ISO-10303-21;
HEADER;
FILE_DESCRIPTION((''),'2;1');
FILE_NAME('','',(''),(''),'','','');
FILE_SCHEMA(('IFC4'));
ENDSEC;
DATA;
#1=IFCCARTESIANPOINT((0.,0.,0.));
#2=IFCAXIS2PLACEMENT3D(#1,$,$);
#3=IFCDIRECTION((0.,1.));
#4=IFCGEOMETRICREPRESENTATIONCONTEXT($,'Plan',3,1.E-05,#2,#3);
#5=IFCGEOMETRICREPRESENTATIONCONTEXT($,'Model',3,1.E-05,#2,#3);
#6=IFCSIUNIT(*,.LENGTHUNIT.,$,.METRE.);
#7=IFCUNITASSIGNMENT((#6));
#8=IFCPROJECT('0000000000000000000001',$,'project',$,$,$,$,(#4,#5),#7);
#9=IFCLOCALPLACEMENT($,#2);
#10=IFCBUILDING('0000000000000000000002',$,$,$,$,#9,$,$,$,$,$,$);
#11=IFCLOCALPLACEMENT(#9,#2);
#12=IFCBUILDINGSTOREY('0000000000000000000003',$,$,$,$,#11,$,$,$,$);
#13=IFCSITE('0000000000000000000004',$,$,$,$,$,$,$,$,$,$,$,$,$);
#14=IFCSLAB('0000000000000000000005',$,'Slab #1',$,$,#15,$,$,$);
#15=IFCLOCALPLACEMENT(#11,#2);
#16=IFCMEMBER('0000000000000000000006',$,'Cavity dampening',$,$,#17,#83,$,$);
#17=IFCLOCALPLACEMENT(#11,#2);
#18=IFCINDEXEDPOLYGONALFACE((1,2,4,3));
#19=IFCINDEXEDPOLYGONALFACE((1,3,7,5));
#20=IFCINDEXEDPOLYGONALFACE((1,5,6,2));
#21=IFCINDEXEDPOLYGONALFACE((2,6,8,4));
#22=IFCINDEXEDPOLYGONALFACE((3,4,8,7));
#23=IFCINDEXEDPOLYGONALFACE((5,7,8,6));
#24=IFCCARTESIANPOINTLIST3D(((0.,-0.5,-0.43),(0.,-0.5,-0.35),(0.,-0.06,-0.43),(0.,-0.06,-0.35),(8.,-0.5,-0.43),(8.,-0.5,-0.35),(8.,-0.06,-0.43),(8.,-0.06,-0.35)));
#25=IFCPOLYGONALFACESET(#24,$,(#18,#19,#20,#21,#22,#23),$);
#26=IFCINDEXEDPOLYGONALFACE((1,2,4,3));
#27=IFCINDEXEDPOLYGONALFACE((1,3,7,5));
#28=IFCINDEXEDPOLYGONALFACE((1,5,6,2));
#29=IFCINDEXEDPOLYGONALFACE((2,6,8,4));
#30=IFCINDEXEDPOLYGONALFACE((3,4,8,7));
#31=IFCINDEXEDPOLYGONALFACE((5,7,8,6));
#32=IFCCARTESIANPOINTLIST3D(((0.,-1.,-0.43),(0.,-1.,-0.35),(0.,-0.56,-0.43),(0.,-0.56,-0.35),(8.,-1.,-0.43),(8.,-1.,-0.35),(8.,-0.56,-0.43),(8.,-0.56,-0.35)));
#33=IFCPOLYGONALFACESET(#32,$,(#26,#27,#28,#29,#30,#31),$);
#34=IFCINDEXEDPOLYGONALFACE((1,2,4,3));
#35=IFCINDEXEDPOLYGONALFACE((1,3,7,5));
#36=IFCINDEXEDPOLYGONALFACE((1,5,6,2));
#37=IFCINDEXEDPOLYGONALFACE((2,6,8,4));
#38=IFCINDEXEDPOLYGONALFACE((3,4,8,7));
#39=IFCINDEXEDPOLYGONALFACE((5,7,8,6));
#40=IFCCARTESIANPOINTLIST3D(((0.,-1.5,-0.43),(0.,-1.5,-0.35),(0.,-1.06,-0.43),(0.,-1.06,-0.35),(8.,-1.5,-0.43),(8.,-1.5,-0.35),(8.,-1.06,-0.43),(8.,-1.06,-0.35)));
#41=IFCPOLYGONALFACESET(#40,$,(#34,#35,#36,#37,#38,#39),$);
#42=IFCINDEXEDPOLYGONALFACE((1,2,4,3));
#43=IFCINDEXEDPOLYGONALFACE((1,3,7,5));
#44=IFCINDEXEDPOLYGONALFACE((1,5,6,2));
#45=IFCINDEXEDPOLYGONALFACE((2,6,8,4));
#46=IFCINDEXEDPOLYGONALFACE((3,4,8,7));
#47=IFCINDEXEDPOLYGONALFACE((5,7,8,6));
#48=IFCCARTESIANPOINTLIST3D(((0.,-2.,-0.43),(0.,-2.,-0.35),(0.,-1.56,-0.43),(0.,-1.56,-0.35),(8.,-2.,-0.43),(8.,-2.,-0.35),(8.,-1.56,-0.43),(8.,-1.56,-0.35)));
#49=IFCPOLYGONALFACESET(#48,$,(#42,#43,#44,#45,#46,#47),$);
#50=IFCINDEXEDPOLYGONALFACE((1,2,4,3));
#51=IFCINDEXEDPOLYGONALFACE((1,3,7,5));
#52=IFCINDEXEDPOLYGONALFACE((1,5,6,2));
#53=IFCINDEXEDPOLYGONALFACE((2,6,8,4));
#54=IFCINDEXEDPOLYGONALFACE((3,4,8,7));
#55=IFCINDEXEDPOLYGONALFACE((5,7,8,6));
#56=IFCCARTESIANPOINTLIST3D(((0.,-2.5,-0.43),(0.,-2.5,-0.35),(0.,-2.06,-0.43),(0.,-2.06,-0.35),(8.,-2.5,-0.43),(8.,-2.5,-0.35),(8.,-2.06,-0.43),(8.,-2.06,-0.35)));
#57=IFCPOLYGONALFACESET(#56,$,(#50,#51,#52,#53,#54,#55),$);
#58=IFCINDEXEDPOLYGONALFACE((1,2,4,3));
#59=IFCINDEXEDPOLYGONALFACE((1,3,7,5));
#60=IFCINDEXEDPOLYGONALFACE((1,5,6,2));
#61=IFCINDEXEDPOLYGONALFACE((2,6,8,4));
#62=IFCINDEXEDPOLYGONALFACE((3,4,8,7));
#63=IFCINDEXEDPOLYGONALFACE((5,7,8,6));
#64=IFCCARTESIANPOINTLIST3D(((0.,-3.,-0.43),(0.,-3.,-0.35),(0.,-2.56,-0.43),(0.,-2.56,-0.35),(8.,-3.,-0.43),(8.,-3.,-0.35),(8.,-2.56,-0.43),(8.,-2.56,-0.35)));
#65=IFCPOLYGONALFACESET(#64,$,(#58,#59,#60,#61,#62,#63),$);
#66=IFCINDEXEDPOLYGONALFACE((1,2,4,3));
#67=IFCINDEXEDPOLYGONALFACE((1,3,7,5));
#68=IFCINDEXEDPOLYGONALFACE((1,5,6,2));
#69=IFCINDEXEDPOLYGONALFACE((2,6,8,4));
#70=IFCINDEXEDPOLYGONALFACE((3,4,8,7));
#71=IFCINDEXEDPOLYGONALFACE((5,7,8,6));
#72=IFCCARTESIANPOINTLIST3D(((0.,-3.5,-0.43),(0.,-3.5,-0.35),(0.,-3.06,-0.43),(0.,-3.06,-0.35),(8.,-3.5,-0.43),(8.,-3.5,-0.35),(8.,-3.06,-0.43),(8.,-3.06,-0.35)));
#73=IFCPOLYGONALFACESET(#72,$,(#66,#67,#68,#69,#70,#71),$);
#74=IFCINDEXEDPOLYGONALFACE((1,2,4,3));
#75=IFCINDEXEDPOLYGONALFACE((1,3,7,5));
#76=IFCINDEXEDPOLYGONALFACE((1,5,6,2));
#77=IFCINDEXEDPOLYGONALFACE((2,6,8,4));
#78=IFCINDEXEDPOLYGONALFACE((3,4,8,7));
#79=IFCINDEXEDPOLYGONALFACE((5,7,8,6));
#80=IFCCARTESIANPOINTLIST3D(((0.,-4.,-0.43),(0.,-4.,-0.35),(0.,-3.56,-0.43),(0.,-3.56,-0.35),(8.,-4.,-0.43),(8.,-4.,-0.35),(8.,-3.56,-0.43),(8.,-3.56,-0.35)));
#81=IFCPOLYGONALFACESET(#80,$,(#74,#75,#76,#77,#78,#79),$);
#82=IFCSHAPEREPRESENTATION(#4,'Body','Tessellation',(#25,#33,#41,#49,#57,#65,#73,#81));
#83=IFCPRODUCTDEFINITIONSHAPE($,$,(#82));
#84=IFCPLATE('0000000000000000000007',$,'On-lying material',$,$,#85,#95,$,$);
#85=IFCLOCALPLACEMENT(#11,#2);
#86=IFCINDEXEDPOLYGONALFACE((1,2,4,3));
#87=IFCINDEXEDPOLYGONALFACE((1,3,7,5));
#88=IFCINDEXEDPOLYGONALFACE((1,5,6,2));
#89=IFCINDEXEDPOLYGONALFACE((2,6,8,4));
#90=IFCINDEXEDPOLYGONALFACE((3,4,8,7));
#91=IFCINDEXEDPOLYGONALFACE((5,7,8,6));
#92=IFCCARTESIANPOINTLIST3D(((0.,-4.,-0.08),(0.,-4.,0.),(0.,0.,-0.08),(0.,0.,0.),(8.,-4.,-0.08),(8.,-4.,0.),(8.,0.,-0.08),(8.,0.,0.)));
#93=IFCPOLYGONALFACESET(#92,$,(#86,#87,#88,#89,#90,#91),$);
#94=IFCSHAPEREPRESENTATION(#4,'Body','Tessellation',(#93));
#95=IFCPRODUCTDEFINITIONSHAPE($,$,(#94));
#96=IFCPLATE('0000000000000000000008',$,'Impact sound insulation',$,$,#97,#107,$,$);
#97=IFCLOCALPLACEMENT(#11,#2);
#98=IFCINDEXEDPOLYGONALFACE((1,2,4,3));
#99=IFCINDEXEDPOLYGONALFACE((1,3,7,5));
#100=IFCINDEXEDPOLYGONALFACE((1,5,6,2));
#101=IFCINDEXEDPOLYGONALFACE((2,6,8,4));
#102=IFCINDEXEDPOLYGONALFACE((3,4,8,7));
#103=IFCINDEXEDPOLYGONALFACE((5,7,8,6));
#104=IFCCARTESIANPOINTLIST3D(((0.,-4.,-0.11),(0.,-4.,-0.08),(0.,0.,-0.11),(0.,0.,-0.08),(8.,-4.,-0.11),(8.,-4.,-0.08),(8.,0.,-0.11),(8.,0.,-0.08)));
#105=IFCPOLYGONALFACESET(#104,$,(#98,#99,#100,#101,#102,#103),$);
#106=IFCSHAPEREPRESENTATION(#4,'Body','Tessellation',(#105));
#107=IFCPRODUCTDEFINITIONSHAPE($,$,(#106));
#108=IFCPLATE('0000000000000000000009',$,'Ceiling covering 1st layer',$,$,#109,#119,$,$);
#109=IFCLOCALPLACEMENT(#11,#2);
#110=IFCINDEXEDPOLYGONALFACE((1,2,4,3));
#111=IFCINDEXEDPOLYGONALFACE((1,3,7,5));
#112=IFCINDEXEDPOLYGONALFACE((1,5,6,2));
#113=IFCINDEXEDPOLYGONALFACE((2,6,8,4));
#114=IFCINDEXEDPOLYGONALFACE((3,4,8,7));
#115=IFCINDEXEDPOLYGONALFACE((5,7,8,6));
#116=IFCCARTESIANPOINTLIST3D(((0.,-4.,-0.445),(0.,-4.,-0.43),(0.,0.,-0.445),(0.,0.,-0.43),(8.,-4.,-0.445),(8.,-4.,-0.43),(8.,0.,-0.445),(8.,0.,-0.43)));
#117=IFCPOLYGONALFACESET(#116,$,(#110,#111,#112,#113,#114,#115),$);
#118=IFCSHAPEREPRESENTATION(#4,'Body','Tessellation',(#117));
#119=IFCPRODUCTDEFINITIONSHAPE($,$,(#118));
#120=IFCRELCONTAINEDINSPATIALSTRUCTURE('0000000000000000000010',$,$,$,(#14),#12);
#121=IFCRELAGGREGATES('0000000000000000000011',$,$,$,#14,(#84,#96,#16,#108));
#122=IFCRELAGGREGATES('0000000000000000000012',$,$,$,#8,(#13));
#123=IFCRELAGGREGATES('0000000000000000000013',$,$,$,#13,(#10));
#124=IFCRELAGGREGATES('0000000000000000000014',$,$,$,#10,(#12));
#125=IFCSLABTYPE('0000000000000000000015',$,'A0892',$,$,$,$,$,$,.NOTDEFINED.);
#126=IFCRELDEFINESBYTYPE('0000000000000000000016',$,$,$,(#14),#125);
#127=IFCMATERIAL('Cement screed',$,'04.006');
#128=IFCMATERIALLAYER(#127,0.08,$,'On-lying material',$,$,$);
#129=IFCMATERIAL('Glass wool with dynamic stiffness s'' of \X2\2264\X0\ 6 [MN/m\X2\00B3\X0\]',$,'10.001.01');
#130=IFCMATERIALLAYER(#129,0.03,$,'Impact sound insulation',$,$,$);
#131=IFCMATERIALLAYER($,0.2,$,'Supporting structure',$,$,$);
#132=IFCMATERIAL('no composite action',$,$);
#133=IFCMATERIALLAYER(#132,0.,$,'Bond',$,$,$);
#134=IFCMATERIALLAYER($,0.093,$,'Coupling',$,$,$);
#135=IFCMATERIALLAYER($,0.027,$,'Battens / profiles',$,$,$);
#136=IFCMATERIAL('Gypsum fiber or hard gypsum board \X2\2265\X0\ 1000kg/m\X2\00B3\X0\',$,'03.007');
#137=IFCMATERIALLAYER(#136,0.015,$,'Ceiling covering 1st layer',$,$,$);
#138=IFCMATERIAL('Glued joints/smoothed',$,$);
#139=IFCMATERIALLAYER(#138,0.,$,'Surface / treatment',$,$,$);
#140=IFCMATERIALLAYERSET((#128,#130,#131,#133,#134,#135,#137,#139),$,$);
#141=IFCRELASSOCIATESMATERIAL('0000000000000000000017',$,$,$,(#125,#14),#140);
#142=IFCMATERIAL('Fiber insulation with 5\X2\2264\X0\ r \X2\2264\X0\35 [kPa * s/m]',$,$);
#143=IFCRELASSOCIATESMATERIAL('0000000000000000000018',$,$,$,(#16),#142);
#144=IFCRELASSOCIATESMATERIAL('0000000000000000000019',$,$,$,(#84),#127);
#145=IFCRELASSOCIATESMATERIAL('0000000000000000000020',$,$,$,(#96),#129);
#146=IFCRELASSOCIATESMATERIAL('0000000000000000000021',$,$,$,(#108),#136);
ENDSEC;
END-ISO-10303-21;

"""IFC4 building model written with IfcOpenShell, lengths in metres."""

from ifc_helpers import new_model, si_unit, direction, frame, frame_2d, origin, origin_with_axes, place, context, project, spatial, rectangle, extrude, material, layer, layer_set, type_object, element, aggregate, save


model = new_model("IFC4")

# Units and contexts
plan_context = context("Plan", 3, precision=1e-05, world=origin(), true_north=direction((0.0, 1.0)))
model_context = context("Model", 3, precision=1e-05, world=origin(), true_north=direction((0.0, 1.0)))
ifc_project = project(units=[si_unit("LENGTHUNIT", "METRE")], contexts=[plan_context, model_context])

# Site, building, storey
site = spatial("IfcSite", under=ifc_project)
building_placement = place(None, origin())
building = spatial("IfcBuilding", under=site, at=building_placement)
storey_placement = place(building_placement, origin())
storey = spatial("IfcBuildingStorey", under=building, at=storey_placement)

# Slab, member, plates
ifc_material_1 = material(Name="Cement screed", Category="04.006")
ifc_layer_1 = layer(ifc_material_1, 0.08, Name="On-lying material")
ifc_material_2 = material(Name="Glass wool with dynamic stiffness s' of ≤ 6 [MN/m³]", Category="10.001.01")
ifc_layer_2 = layer(ifc_material_2, 0.03, Name="Impact sound insulation")
ifc_layer_3 = layer(None, 0.2, Name="Supporting structure")
ifc_material_3 = material(Name="no composite action")
ifc_layer_4 = layer(ifc_material_3, 0.0, Name="Bond")
ifc_layer_5 = layer(None, 0.093, Name="Coupling")
ifc_layer_6 = layer(None, 0.027, Name="Battens / profiles")
ifc_material_4 = material(Name="Gypsum fiber or hard gypsum board ≥ 1000kg/m³", Category="03.007")
ifc_layer_7 = layer(ifc_material_4, 0.015, Name="Ceiling covering 1st layer")
ifc_material_5 = material(Name="Glued joints/smoothed")
ifc_layer_8 = layer(ifc_material_5, 0.0, Name="Surface / treatment")
ifc_layer_set = layer_set([ifc_layer_1, ifc_layer_2, ifc_layer_3, ifc_layer_4, ifc_layer_5, ifc_layer_6, ifc_layer_7, ifc_layer_8])
slab_type = type_object("IfcSlabType", Name="A0892", PredefinedType="NOTDEFINED", material=ifc_layer_set)
slab_placement = place(None, frame((0.0, 0.0, 0.0), z_axis=(0.0, 0.0, -1.0), x_axis=(1.0, 0.0, 0.0)))
slab = element("IfcSlab", 1, at=slab_placement, inside=storey, type_object=slab_type, material=ifc_layer_set, Name="Slab #1")
ifc_material_6 = material(Name="Fiber insulation with 5≤ r ≤35 [kPa * s/m]")
member_1_placement = place(slab_placement, origin())
member_1 = element("IfcMember", 2, at=member_1_placement, material=ifc_material_6, Name="Cavity dampening", context=plan_context, shape_type="SweptSolid", body=[
    extrude(rectangle(XDim=0.44, YDim=0.08, at=frame_2d((0.22, 0.04), x_axis=(1.0, 0.0))), frame((0.0, 0.06, 0.35), z_axis=(1.0, 0.0, 0.0), x_axis=(0.0, 1.0, 0.0)), (0.0, 0.0, 1.0), 8.0),
    extrude(rectangle(XDim=0.44, YDim=0.08, at=frame_2d((0.22, 0.04), x_axis=(1.0, 0.0))), frame((0.0, 0.56, 0.35), z_axis=(1.0, 0.0, 0.0), x_axis=(0.0, 1.0, 0.0)), (0.0, 0.0, 1.0), 8.0),
    extrude(rectangle(XDim=0.44, YDim=0.08, at=frame_2d((0.22, 0.04), x_axis=(1.0, 0.0))), frame((0.0, 1.06, 0.35), z_axis=(1.0, 0.0, 0.0), x_axis=(0.0, 1.0, 0.0)), (0.0, 0.0, 1.0), 8.0),
    extrude(rectangle(XDim=0.44, YDim=0.08, at=frame_2d((0.22, 0.04), x_axis=(1.0, 0.0))), frame((0.0, 1.56, 0.35), z_axis=(1.0, 0.0, 0.0), x_axis=(0.0, 1.0, 0.0)), (0.0, 0.0, 1.0), 8.0),
    extrude(rectangle(XDim=0.44, YDim=0.08, at=frame_2d((0.22, 0.04), x_axis=(1.0, 0.0))), frame((0.0, 2.06, 0.35), z_axis=(1.0, 0.0, 0.0), x_axis=(0.0, 1.0, 0.0)), (0.0, 0.0, 1.0), 8.0),
    extrude(rectangle(XDim=0.44, YDim=0.08, at=frame_2d((0.22, 0.04), x_axis=(1.0, 0.0))), frame((0.0, 2.56, 0.35), z_axis=(1.0, 0.0, 0.0), x_axis=(0.0, 1.0, 0.0)), (0.0, 0.0, 1.0), 8.0),
    extrude(rectangle(XDim=0.44, YDim=0.08, at=frame_2d((0.22, 0.04), x_axis=(1.0, 0.0))), frame((0.0, 3.06, 0.35), z_axis=(1.0, 0.0, 0.0), x_axis=(0.0, 1.0, 0.0)), (0.0, 0.0, 1.0), 8.0),
    extrude(rectangle(XDim=0.44, YDim=0.08, at=frame_2d((0.22, 0.04), x_axis=(1.0, 0.0))), frame((0.0, 3.56, 0.35), z_axis=(1.0, 0.0, 0.0), x_axis=(0.0, 1.0, 0.0)), (0.0, 0.0, 1.0), 8.0),
])
plate_1_placement = place(slab_placement, origin())
plate_1 = element("IfcPlate", 3, at=plate_1_placement, material=ifc_material_1, Name="On-lying material", context=plan_context, shape_type="SweptSolid", body=[
    extrude(rectangle(XDim=8.0, YDim=4.0, at=frame_2d((4.0, 2.0), x_axis=(1.0, 0.0))), origin_with_axes(), (0.0, 0.0, 1.0), 0.08),
])
plate_2_placement = place(slab_placement, origin())
plate_2 = element("IfcPlate", 4, at=plate_2_placement, material=ifc_material_2, Name="Impact sound insulation", context=plan_context, shape_type="SweptSolid", body=[
    extrude(rectangle(XDim=8.0, YDim=4.0, at=frame_2d((4.0, 2.0), x_axis=(1.0, 0.0))), frame((0.0, 0.0, 0.08), z_axis=(0.0, 0.0, 1.0), x_axis=(1.0, 0.0, 0.0)), (0.0, 0.0, 1.0), 0.03),
])
plate_3_placement = place(slab_placement, origin())
plate_3 = element("IfcPlate", 5, at=plate_3_placement, material=ifc_material_4, Name="Ceiling covering 1st layer", context=plan_context, shape_type="SweptSolid", body=[
    extrude(rectangle(XDim=8.0, YDim=4.0, at=frame_2d((4.0, 2.0), x_axis=(1.0, 0.0))), frame((0.0, 0.0, 0.43), z_axis=(0.0, 0.0, 1.0), x_axis=(1.0, 0.0, 0.0)), (0.0, 0.0, 1.0), 0.015),
])
aggregate(slab, [plate_1, plate_2, member_1, plate_3])

save(model, "model.ifc")
